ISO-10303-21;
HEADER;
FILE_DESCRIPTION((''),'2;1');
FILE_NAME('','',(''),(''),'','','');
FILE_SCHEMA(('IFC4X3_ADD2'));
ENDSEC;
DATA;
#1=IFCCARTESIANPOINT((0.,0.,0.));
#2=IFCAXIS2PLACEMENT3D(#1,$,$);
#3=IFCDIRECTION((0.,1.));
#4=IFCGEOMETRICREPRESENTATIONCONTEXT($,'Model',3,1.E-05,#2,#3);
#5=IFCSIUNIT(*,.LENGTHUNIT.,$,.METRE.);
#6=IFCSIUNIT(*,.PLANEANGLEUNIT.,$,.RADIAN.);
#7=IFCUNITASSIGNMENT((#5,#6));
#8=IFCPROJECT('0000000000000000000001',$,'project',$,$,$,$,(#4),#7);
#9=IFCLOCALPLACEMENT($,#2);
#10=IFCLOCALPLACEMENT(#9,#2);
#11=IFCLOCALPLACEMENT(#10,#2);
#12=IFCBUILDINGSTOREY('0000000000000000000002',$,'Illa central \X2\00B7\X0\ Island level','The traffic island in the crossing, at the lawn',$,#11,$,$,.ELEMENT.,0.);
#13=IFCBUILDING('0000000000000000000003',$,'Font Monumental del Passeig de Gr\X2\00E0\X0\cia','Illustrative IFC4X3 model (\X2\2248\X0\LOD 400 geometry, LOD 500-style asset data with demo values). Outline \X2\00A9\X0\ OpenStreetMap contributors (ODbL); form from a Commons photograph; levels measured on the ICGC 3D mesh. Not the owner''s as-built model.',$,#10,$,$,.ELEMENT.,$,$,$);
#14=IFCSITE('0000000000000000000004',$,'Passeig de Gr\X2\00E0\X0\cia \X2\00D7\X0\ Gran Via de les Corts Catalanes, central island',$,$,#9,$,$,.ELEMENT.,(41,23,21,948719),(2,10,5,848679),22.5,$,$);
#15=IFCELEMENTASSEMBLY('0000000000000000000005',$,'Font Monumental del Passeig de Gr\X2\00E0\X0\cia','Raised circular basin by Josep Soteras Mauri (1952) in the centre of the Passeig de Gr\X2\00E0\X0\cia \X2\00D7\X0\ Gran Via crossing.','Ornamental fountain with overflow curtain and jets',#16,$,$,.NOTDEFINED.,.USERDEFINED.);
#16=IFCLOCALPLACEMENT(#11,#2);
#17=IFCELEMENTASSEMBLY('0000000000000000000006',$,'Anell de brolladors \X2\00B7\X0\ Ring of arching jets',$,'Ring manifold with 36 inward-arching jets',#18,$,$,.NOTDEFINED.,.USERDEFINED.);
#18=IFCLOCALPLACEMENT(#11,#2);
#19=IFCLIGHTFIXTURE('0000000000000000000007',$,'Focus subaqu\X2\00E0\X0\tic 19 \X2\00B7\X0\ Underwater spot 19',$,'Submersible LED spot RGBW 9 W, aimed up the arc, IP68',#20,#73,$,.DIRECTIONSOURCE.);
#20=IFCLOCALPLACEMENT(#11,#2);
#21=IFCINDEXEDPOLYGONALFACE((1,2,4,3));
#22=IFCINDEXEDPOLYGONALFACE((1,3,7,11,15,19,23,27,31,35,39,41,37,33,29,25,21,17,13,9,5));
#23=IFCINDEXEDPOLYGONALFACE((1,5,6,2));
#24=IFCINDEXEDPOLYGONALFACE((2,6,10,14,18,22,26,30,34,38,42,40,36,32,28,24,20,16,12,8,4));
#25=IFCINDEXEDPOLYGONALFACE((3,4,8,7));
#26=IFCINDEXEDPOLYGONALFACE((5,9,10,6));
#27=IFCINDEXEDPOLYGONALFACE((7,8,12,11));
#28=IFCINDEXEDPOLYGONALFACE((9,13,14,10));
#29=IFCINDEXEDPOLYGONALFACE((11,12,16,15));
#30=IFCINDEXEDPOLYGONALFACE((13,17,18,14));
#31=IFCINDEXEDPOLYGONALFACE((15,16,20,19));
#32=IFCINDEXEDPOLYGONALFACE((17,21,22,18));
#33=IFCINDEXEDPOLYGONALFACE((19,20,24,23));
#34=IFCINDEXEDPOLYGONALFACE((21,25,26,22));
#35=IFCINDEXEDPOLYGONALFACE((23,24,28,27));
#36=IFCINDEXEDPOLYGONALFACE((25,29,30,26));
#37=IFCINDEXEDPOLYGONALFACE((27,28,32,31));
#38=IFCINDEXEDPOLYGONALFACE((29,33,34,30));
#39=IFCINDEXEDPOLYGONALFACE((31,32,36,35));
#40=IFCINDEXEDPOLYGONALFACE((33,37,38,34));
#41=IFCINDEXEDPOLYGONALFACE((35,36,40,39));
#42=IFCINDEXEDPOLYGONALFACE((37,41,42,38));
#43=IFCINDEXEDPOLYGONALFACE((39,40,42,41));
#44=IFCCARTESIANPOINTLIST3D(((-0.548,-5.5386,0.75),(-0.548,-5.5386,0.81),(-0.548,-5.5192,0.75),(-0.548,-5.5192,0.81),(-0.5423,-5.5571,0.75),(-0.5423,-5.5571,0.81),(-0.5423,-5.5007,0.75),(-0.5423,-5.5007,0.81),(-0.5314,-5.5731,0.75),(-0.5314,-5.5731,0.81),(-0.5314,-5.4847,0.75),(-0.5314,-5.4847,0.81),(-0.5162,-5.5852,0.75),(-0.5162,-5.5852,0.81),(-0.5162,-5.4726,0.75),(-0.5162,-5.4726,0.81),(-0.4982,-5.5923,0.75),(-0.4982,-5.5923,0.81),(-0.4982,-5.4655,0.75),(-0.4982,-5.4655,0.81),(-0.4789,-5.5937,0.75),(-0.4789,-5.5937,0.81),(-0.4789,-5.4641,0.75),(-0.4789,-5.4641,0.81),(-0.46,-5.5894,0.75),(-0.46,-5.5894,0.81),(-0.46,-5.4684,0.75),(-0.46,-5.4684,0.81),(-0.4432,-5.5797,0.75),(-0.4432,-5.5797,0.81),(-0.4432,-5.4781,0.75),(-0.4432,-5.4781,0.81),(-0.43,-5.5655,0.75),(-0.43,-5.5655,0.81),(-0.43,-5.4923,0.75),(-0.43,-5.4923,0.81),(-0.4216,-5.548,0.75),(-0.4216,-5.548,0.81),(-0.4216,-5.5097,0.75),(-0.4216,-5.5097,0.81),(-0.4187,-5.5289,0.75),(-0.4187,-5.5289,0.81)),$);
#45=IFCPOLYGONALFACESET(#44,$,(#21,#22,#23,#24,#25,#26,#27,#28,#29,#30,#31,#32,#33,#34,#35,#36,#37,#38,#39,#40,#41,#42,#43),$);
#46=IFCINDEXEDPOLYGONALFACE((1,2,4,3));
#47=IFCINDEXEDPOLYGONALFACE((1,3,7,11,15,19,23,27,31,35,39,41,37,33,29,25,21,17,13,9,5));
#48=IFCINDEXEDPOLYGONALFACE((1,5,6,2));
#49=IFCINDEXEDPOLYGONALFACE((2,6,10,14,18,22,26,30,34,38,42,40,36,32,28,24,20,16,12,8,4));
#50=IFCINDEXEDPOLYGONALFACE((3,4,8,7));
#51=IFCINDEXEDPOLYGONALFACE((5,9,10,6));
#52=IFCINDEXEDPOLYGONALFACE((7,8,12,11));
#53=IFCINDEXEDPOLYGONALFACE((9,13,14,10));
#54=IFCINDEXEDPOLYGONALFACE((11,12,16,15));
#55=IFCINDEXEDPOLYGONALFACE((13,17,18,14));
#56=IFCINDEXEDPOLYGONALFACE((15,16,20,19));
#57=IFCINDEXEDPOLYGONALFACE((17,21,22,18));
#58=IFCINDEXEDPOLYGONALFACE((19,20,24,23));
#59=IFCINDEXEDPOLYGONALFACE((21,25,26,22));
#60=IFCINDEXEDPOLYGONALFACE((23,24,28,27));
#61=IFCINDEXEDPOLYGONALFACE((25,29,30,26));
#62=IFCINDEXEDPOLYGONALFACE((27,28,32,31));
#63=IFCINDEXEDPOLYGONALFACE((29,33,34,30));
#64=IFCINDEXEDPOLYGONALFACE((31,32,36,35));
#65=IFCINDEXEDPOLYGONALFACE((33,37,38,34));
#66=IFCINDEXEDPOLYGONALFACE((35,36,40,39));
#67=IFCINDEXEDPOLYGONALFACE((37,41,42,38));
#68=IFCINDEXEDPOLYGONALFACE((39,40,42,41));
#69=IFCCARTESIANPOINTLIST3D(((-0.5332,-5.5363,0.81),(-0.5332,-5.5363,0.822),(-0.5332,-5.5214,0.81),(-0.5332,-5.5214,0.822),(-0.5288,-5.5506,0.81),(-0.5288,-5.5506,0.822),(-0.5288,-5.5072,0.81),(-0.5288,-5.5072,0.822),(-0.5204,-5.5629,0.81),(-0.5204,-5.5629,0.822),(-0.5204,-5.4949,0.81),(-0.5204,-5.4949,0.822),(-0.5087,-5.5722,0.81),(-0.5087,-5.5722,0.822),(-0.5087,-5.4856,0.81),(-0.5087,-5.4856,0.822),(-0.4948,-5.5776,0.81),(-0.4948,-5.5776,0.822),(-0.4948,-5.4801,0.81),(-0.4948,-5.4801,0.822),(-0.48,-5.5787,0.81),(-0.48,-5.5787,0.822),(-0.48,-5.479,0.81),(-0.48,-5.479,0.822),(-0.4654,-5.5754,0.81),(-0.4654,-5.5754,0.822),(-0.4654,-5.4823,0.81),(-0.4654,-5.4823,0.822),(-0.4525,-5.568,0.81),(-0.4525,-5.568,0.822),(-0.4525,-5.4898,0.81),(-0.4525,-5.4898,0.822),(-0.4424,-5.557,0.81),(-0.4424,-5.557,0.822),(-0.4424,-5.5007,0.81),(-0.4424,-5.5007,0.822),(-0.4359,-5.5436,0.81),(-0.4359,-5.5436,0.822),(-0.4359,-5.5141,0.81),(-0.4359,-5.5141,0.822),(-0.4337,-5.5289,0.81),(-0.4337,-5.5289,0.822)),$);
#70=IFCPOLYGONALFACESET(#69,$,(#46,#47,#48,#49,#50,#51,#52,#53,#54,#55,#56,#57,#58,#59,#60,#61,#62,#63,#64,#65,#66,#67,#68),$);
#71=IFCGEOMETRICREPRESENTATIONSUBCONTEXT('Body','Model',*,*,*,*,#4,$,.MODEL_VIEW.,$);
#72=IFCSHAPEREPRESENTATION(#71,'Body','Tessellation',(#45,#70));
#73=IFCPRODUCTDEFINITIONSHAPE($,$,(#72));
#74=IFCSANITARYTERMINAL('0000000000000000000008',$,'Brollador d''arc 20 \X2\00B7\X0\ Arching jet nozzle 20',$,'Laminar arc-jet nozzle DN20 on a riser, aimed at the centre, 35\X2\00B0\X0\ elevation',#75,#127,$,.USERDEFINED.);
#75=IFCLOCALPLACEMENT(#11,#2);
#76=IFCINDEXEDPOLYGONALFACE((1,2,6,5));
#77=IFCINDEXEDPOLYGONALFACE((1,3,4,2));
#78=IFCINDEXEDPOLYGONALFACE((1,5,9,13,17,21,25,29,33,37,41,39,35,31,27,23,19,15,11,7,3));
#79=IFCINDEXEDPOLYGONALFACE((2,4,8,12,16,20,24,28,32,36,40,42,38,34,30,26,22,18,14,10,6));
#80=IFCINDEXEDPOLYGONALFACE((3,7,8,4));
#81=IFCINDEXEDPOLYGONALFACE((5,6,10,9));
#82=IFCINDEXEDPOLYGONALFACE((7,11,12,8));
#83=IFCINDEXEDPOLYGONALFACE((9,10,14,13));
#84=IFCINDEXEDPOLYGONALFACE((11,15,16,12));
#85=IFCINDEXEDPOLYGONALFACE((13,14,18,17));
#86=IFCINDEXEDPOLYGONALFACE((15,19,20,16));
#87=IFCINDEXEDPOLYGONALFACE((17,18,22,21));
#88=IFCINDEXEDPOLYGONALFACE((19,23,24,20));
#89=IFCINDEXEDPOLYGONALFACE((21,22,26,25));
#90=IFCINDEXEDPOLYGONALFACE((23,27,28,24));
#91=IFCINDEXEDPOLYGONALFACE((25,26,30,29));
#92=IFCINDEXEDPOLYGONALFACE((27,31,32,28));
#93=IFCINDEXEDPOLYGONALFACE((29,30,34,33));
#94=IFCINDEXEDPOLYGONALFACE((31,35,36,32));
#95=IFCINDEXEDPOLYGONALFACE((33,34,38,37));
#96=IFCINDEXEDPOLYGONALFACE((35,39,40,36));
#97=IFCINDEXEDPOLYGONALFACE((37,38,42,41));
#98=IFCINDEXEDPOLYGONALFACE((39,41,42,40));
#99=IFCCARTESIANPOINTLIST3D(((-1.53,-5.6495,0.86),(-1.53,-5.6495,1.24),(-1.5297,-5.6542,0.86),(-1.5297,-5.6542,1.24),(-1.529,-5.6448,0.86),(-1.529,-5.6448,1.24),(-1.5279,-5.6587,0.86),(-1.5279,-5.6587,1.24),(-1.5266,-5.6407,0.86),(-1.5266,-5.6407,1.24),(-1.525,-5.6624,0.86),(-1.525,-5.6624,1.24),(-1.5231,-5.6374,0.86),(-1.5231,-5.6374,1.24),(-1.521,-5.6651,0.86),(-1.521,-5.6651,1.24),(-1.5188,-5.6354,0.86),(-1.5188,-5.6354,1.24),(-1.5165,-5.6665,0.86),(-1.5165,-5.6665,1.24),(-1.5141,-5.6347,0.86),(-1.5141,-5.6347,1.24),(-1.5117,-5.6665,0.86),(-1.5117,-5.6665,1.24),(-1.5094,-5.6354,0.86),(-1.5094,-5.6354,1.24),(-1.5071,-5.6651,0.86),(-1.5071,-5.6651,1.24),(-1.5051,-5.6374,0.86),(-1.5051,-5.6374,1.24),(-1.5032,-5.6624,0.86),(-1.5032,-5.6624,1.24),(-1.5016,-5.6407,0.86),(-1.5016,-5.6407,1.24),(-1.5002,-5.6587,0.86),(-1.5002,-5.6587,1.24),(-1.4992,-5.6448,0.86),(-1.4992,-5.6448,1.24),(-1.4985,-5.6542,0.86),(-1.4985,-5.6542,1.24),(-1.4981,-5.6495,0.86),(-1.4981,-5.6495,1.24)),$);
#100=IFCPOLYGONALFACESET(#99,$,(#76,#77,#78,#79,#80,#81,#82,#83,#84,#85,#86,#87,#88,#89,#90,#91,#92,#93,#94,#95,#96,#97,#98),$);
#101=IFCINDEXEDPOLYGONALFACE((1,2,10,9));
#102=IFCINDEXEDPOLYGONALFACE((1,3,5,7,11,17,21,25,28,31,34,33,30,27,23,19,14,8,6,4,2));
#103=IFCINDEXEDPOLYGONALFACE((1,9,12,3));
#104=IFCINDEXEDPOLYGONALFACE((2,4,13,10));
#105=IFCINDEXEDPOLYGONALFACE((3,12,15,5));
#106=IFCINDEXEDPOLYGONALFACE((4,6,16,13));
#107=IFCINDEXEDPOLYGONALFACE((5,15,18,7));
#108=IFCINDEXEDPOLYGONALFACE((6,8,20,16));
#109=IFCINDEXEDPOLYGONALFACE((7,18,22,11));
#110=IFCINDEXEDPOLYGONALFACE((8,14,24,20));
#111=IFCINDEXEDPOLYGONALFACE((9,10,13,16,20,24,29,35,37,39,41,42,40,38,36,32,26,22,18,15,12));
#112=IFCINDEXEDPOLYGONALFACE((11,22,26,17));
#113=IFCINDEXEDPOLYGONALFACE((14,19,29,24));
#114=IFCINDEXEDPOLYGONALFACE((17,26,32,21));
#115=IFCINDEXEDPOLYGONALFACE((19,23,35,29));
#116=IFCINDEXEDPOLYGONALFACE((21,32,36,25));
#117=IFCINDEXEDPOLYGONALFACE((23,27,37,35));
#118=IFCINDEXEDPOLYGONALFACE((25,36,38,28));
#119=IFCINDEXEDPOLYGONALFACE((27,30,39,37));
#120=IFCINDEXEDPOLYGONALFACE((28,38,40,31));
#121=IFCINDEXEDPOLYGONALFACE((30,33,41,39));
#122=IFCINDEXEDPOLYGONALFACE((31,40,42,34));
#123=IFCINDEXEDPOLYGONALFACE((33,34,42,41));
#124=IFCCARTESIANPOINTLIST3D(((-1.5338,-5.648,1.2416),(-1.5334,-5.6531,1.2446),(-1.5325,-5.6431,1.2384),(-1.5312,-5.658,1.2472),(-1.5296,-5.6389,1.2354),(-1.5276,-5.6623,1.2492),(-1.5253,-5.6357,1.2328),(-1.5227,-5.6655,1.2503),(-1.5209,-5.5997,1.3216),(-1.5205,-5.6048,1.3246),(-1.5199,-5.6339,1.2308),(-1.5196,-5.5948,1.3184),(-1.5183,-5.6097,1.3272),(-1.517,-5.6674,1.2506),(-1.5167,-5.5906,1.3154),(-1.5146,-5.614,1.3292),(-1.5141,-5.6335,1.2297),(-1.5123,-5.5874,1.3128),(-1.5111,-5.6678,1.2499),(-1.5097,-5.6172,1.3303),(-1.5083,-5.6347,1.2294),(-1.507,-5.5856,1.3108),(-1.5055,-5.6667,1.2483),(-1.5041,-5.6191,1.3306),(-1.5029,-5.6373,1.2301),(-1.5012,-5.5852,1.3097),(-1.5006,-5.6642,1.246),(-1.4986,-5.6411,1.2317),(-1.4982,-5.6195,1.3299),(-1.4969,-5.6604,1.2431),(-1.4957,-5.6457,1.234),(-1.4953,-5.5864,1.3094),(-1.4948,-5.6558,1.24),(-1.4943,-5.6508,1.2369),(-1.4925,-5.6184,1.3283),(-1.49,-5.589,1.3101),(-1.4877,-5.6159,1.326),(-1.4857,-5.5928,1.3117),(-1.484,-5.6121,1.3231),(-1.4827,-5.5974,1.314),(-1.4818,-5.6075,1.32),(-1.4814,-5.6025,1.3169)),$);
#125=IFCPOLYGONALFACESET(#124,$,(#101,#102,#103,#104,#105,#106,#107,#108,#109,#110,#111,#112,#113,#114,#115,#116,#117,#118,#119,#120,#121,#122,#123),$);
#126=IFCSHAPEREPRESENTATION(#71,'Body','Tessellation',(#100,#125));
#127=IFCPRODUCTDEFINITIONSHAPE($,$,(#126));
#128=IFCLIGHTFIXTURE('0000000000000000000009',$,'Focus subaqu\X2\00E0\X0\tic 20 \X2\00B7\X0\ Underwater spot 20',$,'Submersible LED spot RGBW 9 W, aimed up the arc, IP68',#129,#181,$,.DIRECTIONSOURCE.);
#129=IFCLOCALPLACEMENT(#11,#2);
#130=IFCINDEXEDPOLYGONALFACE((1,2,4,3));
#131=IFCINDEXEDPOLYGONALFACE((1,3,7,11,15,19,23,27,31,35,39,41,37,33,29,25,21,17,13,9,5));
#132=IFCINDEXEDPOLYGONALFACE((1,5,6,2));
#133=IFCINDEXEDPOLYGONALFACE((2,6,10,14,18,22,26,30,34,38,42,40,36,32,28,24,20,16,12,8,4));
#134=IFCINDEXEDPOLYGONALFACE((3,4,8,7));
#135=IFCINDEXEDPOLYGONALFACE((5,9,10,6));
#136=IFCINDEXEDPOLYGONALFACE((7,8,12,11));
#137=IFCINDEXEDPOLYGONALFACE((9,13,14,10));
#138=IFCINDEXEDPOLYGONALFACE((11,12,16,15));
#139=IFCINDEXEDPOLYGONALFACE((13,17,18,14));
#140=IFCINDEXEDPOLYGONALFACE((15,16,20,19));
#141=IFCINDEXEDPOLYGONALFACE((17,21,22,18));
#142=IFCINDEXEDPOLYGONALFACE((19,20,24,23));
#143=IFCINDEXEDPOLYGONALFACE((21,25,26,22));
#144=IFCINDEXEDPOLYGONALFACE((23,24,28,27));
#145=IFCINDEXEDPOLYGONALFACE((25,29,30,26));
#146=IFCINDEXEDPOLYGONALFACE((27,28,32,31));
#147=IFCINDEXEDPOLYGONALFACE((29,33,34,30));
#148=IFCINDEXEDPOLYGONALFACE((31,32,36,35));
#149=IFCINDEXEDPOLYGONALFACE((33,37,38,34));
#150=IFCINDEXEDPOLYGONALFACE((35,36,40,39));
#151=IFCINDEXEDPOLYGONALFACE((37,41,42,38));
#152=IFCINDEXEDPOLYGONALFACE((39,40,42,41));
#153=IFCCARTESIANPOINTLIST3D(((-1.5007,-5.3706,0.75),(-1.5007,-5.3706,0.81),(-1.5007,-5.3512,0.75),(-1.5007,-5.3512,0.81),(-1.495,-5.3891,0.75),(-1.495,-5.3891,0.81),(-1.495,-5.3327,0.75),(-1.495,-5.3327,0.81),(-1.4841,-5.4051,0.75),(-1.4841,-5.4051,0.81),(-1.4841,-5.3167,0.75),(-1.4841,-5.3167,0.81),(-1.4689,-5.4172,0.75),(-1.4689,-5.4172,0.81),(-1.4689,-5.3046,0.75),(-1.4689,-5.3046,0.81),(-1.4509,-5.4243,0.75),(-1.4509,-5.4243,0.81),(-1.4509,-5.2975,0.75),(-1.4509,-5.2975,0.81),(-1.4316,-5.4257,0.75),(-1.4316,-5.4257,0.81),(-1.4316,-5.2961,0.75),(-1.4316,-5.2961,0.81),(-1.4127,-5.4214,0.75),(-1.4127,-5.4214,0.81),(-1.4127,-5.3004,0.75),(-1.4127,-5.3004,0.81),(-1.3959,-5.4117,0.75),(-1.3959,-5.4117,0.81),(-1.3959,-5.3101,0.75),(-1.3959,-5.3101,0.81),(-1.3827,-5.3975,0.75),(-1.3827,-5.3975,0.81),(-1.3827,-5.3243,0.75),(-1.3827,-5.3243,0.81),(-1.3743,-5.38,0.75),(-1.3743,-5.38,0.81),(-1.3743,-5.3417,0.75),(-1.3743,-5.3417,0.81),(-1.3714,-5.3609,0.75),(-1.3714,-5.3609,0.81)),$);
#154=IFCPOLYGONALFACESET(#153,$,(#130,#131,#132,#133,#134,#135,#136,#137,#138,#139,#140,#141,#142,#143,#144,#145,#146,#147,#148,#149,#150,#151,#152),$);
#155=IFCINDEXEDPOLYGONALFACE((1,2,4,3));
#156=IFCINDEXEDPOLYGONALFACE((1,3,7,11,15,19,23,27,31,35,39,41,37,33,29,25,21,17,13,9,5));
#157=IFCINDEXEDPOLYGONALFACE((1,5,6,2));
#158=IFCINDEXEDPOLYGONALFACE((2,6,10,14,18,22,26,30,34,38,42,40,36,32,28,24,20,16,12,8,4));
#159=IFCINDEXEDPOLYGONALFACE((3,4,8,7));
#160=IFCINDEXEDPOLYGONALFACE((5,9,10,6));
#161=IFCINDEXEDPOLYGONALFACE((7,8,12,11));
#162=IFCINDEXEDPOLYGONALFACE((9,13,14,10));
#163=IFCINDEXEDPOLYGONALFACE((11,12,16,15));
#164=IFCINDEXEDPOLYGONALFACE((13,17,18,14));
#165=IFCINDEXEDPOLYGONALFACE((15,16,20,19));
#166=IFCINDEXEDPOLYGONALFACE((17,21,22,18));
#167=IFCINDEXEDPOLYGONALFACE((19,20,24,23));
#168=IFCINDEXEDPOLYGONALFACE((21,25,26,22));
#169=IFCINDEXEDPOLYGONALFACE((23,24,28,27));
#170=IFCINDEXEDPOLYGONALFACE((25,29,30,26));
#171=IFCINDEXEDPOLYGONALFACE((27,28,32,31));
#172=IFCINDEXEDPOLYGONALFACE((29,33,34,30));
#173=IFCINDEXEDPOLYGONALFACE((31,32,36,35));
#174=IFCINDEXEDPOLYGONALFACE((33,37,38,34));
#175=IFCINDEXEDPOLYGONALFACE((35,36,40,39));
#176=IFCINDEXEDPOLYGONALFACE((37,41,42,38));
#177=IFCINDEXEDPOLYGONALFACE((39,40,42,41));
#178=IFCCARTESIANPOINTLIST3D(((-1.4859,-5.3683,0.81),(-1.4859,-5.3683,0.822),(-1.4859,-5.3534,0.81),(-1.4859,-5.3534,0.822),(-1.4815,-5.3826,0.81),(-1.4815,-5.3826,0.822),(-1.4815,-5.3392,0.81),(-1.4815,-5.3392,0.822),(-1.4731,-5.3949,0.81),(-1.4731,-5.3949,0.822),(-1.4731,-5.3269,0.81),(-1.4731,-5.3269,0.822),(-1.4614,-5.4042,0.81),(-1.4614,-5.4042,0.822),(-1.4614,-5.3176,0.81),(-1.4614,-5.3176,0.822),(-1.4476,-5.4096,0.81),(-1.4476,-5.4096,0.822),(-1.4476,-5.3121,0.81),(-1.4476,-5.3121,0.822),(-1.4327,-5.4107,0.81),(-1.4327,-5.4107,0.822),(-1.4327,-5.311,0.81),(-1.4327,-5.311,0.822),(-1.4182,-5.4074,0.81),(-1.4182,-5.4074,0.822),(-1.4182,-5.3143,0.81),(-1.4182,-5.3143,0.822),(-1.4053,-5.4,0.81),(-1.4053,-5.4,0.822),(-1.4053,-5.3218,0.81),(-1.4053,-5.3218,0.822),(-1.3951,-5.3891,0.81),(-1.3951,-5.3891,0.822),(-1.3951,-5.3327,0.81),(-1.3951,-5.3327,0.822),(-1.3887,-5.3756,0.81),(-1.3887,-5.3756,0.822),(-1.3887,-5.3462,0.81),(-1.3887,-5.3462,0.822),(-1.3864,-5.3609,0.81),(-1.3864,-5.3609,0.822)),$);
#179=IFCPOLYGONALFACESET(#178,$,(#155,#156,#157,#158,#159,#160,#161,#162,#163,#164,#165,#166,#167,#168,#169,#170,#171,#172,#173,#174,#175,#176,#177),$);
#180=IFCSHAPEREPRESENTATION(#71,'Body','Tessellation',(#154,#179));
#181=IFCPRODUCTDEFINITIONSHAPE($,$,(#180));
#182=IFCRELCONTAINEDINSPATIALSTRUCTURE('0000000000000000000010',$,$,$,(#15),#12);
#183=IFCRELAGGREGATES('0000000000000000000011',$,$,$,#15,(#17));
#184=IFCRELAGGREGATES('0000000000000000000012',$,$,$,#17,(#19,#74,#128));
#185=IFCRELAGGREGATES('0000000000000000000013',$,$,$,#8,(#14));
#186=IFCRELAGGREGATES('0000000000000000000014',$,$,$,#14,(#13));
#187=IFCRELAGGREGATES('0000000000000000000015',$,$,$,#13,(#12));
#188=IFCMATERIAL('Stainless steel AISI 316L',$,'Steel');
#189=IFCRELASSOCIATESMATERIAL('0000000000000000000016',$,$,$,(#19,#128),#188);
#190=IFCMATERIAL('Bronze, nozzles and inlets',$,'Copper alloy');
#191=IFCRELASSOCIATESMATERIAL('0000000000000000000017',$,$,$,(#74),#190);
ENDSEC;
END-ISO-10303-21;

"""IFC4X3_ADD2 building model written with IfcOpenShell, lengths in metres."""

from ifc_helpers import new_model, si_unit, direction, frame, origin, origin_2d_with_axis, place, context, subcontext, project, spatial, circle, extrude, material, element, aggregate, save


model = new_model("IFC4X3_ADD2")

# Units and contexts
model_context = context("Model", 3, precision=1e-05, world=origin(), true_north=direction((0.0, 1.0)))
body_context = subcontext(model_context, "Body", "Model", "MODEL_VIEW")
ifc_project = project(units=[si_unit("LENGTHUNIT", "METRE"), si_unit("PLANEANGLEUNIT", "RADIAN")], contexts=[model_context])

# Site, building, storey
site_placement = place(None, origin())
site = spatial("IfcSite", under=ifc_project, at=site_placement, Name="Passeig de Gràcia × Gran Via de les Corts Catalanes, central island", CompositionType="ELEMENT", RefLatitude=(41, 23, 21, 948719), RefLongitude=(2, 10, 5, 848679), RefElevation=22.5)
building_placement = place(site_placement, origin())
building = spatial("IfcBuilding", under=site, at=building_placement, Name="Font Monumental del Passeig de Gràcia", Description="Illustrative IFC4X3 model (≈LOD 400 geometry, LOD 500-style asset data with demo values). Outline © OpenStreetMap contributors (ODbL); form from a Commons photograph; levels measured on the ICGC 3D mesh. Not the owner's as-built model.", CompositionType="ELEMENT")
storey_placement = place(building_placement, origin())
storey = spatial("IfcBuildingStorey", under=building, at=storey_placement, Name="Illa central · Island level", Description="The traffic island in the crossing, at the lawn", CompositionType="ELEMENT", Elevation=0.0)

# Element assemblies, light fixtures, sanitary terminal
assembly_1_placement = place(building_placement, origin())
assembly_1 = element("IfcElementAssembly", 1, at=assembly_1_placement, inside=storey, Name="Font Monumental del Passeig de Gràcia", Description="Raised circular basin by Josep Soteras Mauri (1952) in the centre of the Passeig de Gràcia × Gran Via crossing.", ObjectType="Ornamental fountain with overflow curtain and jets", AssemblyPlace="NOTDEFINED", PredefinedType="USERDEFINED")
assembly_2_placement = place(building_placement, origin())
assembly_2 = element("IfcElementAssembly", 2, at=assembly_2_placement, Name="Anell de brolladors · Ring of arching jets", ObjectType="Ring manifold with 36 inward-arching jets", AssemblyPlace="NOTDEFINED", PredefinedType="USERDEFINED")
aggregate(assembly_1, [assembly_2])
ifc_material_1 = material(Name="Stainless steel AISI 316L", Category="Steel")
light_fixture_1_placement = place(building_placement, origin())
light_fixture_1 = element("IfcLightFixture", 3, at=light_fixture_1_placement, material=ifc_material_1, Name="Focus subaquàtic 19 · Underwater spot 19", ObjectType="Submersible LED spot RGBW 9 W, aimed up the arc, IP68", PredefinedType="DIRECTIONSOURCE", context=body_context, shape_type="SweptSolid", body=[
    extrude(circle(Radius=0.065, at=origin_2d_with_axis()), frame((-0.4837, -5.5289, 0.75)), (0.0, 0.0, 1.0), 0.06),
    extrude(circle(Radius=0.05, at=origin_2d_with_axis()), frame((-0.4837, -5.5289, 0.81)), (0.0, 0.0, 1.0), 0.012),
])
ifc_material_2 = material(Name="Bronze, nozzles and inlets", Category="Copper alloy")
sanitary_terminal_1_placement = place(building_placement, origin())
sanitary_terminal_1 = element("IfcSanitaryTerminal", 4, at=sanitary_terminal_1_placement, material=ifc_material_2, Name="Brollador d'arc 20 · Arching jet nozzle 20", ObjectType="Laminar arc-jet nozzle DN20 on a riser, aimed at the centre, 35° elevation", PredefinedType="USERDEFINED", context=body_context, shape_type="SweptSolid", body=[
    extrude(circle(Radius=0.016, at=origin_2d_with_axis()), frame((-1.5141, -5.6507, 0.86), z_axis=(0.0, 0.0, 1.0), x_axis=(0.0, 1.0, 0.0)), (0.0, 0.0, 1.0), 0.38),
    extrude(circle(Radius=0.02, at=origin_2d_with_axis()), frame((-1.5141, -5.6507, 1.24), z_axis=(0.137174, 0.51194, 0.847998), x_axis=(0.965926, -0.258819, 0.0)), (0.0, 0.0, 1.0), 0.0943),
])
light_fixture_2_placement = place(building_placement, origin())
light_fixture_2 = element("IfcLightFixture", 5, at=light_fixture_2_placement, material=ifc_material_1, Name="Focus subaquàtic 20 · Underwater spot 20", ObjectType="Submersible LED spot RGBW 9 W, aimed up the arc, IP68", PredefinedType="DIRECTIONSOURCE", context=body_context, shape_type="SweptSolid", body=[
    extrude(circle(Radius=0.065, at=origin_2d_with_axis()), frame((-1.4364, -5.3609, 0.75)), (0.0, 0.0, 1.0), 0.06),
    extrude(circle(Radius=0.05, at=origin_2d_with_axis()), frame((-1.4364, -5.3609, 0.81)), (0.0, 0.0, 1.0), 0.012),
])
aggregate(assembly_2, [light_fixture_1, sanitary_terminal_1, light_fixture_2])

save(model, "model.ifc")
